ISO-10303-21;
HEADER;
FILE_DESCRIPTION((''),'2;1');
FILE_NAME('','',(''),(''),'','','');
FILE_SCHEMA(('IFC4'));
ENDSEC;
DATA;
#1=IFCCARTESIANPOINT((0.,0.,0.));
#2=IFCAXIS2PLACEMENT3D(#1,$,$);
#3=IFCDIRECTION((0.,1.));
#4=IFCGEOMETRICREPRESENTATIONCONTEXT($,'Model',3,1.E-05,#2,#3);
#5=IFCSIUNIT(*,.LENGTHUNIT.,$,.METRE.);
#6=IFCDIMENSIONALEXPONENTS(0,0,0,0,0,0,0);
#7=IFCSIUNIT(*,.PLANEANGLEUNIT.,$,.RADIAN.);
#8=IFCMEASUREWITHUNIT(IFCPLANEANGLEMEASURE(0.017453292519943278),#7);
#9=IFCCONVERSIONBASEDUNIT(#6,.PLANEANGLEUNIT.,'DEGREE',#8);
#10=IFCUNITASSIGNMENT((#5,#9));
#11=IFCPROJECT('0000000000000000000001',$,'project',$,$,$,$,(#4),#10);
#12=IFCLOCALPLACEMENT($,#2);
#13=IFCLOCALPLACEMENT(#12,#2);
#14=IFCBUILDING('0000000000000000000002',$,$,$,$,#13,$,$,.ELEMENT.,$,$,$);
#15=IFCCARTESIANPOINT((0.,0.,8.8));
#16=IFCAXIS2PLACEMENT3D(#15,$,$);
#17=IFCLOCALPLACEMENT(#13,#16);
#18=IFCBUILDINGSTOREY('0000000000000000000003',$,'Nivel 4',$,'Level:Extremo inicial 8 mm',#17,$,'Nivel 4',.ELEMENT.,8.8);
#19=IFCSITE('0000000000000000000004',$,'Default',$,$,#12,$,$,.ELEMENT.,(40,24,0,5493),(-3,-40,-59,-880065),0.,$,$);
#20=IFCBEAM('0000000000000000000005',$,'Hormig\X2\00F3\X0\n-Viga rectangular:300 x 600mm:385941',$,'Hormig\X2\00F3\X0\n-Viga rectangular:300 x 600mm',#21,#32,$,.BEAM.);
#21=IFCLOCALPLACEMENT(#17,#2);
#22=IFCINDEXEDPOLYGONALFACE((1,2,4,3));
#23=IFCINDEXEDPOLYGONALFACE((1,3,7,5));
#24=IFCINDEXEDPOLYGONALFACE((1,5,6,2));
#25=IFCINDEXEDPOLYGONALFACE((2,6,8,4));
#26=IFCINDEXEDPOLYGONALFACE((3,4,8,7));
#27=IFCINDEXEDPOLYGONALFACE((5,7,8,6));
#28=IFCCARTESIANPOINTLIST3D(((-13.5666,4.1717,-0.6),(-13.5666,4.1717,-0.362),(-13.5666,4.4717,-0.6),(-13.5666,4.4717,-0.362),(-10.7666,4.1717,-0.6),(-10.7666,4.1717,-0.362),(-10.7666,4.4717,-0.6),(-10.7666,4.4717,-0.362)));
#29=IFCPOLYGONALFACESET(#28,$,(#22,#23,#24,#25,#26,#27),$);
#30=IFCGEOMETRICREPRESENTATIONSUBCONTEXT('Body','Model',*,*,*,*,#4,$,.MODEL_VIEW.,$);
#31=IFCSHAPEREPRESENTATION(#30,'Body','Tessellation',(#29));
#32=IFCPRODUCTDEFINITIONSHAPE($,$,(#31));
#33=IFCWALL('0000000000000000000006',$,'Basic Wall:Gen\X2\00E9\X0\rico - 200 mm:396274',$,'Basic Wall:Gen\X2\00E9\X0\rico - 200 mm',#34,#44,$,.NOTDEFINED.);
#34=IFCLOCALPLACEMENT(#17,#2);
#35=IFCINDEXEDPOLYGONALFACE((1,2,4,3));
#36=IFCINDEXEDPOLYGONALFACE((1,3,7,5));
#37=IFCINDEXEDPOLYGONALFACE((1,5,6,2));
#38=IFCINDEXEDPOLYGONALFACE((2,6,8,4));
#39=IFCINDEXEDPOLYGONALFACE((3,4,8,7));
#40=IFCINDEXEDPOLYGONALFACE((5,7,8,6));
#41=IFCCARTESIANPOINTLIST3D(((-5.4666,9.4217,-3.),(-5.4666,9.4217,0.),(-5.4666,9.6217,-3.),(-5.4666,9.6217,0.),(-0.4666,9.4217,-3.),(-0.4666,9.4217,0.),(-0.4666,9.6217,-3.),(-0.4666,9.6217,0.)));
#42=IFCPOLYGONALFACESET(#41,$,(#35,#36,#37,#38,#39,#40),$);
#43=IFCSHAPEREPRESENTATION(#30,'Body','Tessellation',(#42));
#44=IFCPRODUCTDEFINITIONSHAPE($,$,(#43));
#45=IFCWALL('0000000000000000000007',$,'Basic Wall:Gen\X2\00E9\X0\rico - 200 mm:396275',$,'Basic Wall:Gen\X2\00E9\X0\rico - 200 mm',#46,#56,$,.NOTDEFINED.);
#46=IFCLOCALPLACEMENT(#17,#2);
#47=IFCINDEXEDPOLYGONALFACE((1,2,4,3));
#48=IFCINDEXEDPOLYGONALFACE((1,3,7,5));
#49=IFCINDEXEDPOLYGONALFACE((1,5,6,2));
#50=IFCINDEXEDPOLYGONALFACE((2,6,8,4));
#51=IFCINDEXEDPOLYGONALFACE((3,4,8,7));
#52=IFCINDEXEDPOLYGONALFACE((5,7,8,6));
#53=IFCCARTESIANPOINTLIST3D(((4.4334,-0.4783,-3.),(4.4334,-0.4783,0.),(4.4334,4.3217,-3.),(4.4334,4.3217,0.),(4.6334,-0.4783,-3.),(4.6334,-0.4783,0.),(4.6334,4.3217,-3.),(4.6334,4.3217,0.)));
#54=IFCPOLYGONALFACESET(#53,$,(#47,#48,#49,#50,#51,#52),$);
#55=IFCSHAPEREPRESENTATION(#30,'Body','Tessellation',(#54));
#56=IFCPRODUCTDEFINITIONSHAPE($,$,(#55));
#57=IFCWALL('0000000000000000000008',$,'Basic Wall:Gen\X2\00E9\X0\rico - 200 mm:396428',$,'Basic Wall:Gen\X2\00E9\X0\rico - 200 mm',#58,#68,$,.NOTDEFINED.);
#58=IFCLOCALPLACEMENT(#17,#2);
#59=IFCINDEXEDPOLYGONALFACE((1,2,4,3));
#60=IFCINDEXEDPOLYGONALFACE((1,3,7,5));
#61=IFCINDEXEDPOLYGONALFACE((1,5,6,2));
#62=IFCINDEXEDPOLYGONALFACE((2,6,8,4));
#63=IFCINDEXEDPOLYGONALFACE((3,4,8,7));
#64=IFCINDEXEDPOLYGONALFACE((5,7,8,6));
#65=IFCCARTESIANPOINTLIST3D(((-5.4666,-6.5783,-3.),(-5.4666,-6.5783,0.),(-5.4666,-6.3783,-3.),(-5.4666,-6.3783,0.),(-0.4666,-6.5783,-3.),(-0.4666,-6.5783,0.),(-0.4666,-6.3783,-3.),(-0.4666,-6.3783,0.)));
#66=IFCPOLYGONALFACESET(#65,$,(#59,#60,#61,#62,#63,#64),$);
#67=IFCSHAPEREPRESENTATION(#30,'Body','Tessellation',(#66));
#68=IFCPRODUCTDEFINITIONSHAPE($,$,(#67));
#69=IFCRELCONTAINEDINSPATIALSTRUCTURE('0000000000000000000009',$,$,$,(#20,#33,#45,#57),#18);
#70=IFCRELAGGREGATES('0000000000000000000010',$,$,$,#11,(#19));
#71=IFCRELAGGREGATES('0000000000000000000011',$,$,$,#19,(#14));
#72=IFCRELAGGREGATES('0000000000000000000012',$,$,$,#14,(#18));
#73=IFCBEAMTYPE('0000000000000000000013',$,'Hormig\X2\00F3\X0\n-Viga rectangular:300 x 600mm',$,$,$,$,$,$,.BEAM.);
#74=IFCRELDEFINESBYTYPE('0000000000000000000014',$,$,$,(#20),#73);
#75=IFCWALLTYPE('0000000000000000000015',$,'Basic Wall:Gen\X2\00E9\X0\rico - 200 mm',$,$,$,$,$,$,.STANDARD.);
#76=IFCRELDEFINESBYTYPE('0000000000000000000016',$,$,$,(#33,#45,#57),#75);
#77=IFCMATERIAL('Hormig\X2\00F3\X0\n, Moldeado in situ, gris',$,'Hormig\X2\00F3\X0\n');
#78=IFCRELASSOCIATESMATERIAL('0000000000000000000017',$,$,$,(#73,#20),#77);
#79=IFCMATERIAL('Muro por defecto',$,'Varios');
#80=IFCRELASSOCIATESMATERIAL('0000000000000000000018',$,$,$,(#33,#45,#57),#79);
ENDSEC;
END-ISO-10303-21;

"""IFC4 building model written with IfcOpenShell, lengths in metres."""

from ifc_helpers import new_model, entity, si_unit, converted_unit, direction, frame, origin, place, context, subcontext, project, spatial, indexed_curve, outline, extrude, source, transform, mapped, material, type_object, type_shapes, element, save


model = new_model("IFC4")

# Units and contexts
model_context = context("Model", 3, precision=1e-05, world=origin(), true_north=direction((0.0, 1.0)))
body_context = subcontext(model_context, "Body", "Model", "MODEL_VIEW")
ifc_project = project(units=[si_unit("LENGTHUNIT", "METRE"), converted_unit("PLANEANGLEUNIT", "DEGREE", entity("IfcPlaneAngleMeasure", 0.017453292519943278), si_unit("PLANEANGLEUNIT", "RADIAN"), dimensions=[0, 0, 0, 0, 0, 0, 0])], contexts=[model_context])

# Site, building, storey
site_placement = place(None, origin())
site = spatial("IfcSite", under=ifc_project, at=site_placement, Name="Default", CompositionType="ELEMENT", RefLatitude=(40, 24, 0, 5493), RefLongitude=(-3, -40, -59, -880065), RefElevation=0.0)
building_placement = place(site_placement, origin())
building = spatial("IfcBuilding", under=site, at=building_placement, CompositionType="ELEMENT")
storey_placement = place(building_placement, frame((0.0, 0.0, 8.8)))
storey = spatial("IfcBuildingStorey", under=building, at=storey_placement, Name="Nivel 4", ObjectType="Level:Extremo inicial 8 mm", LongName="Nivel 4", CompositionType="ELEMENT", Elevation=8.8)

# Shared definitions
ifc_material_1 = material(Name="Hormigón, Moldeado in situ, gris", Category="Hormigón")

# Beam
beam_type_1 = type_object("IfcBeamType", Name="Hormigón-Viga rectangular:300 x 600mm", PredefinedType="BEAM", material=ifc_material_1)
shared_shape_1 = source(origin(), body_context, "Body", "SweptSolid", [
    extrude(outline(indexed_curve([(-0.119, -0.15), (0.119, -0.15), (0.119, 0.15), (-0.119, 0.15), (-0.119, -0.15)], self_intersect=False)), frame((-10.7666, 4.3217, 8.319), z_axis=(-1.0, 0.0, 0.0), x_axis=(0.0, 0.0, -1.0)), (0.0, 0.0, 1.0), 2.8),
])
type_shapes(beam_type_1, [shared_shape_1])
beam_1_placement = place(storey_placement, frame((0.0, 0.0, -8.8)))
element("IfcBeam", 1, at=beam_1_placement, inside=storey, type_object=beam_type_1, material=ifc_material_1, Name="Hormigón-Viga rectangular:300 x 600mm:385941", ObjectType="Hormigón-Viga rectangular:300 x 600mm", PredefinedType="BEAM", context=body_context, shape_type="MappedRepresentation", body=[
    mapped(shared_shape_1, transform((0.0, 0.0, 0.0), scale=1.0)),
])

# Walls
ifc_material_2 = material(Name="Muro por defecto", Category="Varios")
wall_type = type_object("IfcWallType", Name="Basic Wall:Genérico - 200 mm", PredefinedType="STANDARD")
wall_1_placement = place(storey_placement, frame((-5.4666, 9.5217, -3.0)))
element("IfcWall", 2, at=wall_1_placement, inside=storey, type_object=wall_type, material=ifc_material_2, Name="Basic Wall:Genérico - 200 mm:396274", ObjectType="Basic Wall:Genérico - 200 mm", PredefinedType="NOTDEFINED", context=body_context, shape_type="SweptSolid", body=[
    extrude(outline(indexed_curve([(5.0, 0.1), (0.0, 0.1), (0.0, -0.1), (5.0, -0.1), (5.0, 0.1)], self_intersect=False)), origin(), (0.0, 0.0, 1.0), 3.0),
])
wall_2_placement = place(storey_placement, frame((4.5334, 4.3217, -3.0), z_axis=(0.0, 0.0, 1.0), x_axis=(0.0, -1.0, 0.0)))
element("IfcWall", 3, at=wall_2_placement, inside=storey, type_object=wall_type, material=ifc_material_2, Name="Basic Wall:Genérico - 200 mm:396275", ObjectType="Basic Wall:Genérico - 200 mm", PredefinedType="NOTDEFINED", context=body_context, shape_type="SweptSolid", body=[
    extrude(outline(indexed_curve([(4.8, 0.1), (0.0, 0.1), (0.0, -0.1), (4.8, -0.1), (4.8, 0.1)], self_intersect=False)), origin(), (0.0, 0.0, 1.0), 3.0),
])
wall_3_placement = place(storey_placement, frame((-5.4666, -6.4783, -3.0)))
element("IfcWall", 4, at=wall_3_placement, inside=storey, type_object=wall_type, material=ifc_material_2, Name="Basic Wall:Genérico - 200 mm:396428", ObjectType="Basic Wall:Genérico - 200 mm", PredefinedType="NOTDEFINED", context=body_context, shape_type="SweptSolid", body=[
    extrude(outline(indexed_curve([(5.0, 0.1), (0.0, 0.1), (0.0, -0.1), (5.0, -0.1), (5.0, 0.1)], self_intersect=False)), origin(), (0.0, 0.0, 1.0), 3.0),
])

save(model, "model.ifc")
